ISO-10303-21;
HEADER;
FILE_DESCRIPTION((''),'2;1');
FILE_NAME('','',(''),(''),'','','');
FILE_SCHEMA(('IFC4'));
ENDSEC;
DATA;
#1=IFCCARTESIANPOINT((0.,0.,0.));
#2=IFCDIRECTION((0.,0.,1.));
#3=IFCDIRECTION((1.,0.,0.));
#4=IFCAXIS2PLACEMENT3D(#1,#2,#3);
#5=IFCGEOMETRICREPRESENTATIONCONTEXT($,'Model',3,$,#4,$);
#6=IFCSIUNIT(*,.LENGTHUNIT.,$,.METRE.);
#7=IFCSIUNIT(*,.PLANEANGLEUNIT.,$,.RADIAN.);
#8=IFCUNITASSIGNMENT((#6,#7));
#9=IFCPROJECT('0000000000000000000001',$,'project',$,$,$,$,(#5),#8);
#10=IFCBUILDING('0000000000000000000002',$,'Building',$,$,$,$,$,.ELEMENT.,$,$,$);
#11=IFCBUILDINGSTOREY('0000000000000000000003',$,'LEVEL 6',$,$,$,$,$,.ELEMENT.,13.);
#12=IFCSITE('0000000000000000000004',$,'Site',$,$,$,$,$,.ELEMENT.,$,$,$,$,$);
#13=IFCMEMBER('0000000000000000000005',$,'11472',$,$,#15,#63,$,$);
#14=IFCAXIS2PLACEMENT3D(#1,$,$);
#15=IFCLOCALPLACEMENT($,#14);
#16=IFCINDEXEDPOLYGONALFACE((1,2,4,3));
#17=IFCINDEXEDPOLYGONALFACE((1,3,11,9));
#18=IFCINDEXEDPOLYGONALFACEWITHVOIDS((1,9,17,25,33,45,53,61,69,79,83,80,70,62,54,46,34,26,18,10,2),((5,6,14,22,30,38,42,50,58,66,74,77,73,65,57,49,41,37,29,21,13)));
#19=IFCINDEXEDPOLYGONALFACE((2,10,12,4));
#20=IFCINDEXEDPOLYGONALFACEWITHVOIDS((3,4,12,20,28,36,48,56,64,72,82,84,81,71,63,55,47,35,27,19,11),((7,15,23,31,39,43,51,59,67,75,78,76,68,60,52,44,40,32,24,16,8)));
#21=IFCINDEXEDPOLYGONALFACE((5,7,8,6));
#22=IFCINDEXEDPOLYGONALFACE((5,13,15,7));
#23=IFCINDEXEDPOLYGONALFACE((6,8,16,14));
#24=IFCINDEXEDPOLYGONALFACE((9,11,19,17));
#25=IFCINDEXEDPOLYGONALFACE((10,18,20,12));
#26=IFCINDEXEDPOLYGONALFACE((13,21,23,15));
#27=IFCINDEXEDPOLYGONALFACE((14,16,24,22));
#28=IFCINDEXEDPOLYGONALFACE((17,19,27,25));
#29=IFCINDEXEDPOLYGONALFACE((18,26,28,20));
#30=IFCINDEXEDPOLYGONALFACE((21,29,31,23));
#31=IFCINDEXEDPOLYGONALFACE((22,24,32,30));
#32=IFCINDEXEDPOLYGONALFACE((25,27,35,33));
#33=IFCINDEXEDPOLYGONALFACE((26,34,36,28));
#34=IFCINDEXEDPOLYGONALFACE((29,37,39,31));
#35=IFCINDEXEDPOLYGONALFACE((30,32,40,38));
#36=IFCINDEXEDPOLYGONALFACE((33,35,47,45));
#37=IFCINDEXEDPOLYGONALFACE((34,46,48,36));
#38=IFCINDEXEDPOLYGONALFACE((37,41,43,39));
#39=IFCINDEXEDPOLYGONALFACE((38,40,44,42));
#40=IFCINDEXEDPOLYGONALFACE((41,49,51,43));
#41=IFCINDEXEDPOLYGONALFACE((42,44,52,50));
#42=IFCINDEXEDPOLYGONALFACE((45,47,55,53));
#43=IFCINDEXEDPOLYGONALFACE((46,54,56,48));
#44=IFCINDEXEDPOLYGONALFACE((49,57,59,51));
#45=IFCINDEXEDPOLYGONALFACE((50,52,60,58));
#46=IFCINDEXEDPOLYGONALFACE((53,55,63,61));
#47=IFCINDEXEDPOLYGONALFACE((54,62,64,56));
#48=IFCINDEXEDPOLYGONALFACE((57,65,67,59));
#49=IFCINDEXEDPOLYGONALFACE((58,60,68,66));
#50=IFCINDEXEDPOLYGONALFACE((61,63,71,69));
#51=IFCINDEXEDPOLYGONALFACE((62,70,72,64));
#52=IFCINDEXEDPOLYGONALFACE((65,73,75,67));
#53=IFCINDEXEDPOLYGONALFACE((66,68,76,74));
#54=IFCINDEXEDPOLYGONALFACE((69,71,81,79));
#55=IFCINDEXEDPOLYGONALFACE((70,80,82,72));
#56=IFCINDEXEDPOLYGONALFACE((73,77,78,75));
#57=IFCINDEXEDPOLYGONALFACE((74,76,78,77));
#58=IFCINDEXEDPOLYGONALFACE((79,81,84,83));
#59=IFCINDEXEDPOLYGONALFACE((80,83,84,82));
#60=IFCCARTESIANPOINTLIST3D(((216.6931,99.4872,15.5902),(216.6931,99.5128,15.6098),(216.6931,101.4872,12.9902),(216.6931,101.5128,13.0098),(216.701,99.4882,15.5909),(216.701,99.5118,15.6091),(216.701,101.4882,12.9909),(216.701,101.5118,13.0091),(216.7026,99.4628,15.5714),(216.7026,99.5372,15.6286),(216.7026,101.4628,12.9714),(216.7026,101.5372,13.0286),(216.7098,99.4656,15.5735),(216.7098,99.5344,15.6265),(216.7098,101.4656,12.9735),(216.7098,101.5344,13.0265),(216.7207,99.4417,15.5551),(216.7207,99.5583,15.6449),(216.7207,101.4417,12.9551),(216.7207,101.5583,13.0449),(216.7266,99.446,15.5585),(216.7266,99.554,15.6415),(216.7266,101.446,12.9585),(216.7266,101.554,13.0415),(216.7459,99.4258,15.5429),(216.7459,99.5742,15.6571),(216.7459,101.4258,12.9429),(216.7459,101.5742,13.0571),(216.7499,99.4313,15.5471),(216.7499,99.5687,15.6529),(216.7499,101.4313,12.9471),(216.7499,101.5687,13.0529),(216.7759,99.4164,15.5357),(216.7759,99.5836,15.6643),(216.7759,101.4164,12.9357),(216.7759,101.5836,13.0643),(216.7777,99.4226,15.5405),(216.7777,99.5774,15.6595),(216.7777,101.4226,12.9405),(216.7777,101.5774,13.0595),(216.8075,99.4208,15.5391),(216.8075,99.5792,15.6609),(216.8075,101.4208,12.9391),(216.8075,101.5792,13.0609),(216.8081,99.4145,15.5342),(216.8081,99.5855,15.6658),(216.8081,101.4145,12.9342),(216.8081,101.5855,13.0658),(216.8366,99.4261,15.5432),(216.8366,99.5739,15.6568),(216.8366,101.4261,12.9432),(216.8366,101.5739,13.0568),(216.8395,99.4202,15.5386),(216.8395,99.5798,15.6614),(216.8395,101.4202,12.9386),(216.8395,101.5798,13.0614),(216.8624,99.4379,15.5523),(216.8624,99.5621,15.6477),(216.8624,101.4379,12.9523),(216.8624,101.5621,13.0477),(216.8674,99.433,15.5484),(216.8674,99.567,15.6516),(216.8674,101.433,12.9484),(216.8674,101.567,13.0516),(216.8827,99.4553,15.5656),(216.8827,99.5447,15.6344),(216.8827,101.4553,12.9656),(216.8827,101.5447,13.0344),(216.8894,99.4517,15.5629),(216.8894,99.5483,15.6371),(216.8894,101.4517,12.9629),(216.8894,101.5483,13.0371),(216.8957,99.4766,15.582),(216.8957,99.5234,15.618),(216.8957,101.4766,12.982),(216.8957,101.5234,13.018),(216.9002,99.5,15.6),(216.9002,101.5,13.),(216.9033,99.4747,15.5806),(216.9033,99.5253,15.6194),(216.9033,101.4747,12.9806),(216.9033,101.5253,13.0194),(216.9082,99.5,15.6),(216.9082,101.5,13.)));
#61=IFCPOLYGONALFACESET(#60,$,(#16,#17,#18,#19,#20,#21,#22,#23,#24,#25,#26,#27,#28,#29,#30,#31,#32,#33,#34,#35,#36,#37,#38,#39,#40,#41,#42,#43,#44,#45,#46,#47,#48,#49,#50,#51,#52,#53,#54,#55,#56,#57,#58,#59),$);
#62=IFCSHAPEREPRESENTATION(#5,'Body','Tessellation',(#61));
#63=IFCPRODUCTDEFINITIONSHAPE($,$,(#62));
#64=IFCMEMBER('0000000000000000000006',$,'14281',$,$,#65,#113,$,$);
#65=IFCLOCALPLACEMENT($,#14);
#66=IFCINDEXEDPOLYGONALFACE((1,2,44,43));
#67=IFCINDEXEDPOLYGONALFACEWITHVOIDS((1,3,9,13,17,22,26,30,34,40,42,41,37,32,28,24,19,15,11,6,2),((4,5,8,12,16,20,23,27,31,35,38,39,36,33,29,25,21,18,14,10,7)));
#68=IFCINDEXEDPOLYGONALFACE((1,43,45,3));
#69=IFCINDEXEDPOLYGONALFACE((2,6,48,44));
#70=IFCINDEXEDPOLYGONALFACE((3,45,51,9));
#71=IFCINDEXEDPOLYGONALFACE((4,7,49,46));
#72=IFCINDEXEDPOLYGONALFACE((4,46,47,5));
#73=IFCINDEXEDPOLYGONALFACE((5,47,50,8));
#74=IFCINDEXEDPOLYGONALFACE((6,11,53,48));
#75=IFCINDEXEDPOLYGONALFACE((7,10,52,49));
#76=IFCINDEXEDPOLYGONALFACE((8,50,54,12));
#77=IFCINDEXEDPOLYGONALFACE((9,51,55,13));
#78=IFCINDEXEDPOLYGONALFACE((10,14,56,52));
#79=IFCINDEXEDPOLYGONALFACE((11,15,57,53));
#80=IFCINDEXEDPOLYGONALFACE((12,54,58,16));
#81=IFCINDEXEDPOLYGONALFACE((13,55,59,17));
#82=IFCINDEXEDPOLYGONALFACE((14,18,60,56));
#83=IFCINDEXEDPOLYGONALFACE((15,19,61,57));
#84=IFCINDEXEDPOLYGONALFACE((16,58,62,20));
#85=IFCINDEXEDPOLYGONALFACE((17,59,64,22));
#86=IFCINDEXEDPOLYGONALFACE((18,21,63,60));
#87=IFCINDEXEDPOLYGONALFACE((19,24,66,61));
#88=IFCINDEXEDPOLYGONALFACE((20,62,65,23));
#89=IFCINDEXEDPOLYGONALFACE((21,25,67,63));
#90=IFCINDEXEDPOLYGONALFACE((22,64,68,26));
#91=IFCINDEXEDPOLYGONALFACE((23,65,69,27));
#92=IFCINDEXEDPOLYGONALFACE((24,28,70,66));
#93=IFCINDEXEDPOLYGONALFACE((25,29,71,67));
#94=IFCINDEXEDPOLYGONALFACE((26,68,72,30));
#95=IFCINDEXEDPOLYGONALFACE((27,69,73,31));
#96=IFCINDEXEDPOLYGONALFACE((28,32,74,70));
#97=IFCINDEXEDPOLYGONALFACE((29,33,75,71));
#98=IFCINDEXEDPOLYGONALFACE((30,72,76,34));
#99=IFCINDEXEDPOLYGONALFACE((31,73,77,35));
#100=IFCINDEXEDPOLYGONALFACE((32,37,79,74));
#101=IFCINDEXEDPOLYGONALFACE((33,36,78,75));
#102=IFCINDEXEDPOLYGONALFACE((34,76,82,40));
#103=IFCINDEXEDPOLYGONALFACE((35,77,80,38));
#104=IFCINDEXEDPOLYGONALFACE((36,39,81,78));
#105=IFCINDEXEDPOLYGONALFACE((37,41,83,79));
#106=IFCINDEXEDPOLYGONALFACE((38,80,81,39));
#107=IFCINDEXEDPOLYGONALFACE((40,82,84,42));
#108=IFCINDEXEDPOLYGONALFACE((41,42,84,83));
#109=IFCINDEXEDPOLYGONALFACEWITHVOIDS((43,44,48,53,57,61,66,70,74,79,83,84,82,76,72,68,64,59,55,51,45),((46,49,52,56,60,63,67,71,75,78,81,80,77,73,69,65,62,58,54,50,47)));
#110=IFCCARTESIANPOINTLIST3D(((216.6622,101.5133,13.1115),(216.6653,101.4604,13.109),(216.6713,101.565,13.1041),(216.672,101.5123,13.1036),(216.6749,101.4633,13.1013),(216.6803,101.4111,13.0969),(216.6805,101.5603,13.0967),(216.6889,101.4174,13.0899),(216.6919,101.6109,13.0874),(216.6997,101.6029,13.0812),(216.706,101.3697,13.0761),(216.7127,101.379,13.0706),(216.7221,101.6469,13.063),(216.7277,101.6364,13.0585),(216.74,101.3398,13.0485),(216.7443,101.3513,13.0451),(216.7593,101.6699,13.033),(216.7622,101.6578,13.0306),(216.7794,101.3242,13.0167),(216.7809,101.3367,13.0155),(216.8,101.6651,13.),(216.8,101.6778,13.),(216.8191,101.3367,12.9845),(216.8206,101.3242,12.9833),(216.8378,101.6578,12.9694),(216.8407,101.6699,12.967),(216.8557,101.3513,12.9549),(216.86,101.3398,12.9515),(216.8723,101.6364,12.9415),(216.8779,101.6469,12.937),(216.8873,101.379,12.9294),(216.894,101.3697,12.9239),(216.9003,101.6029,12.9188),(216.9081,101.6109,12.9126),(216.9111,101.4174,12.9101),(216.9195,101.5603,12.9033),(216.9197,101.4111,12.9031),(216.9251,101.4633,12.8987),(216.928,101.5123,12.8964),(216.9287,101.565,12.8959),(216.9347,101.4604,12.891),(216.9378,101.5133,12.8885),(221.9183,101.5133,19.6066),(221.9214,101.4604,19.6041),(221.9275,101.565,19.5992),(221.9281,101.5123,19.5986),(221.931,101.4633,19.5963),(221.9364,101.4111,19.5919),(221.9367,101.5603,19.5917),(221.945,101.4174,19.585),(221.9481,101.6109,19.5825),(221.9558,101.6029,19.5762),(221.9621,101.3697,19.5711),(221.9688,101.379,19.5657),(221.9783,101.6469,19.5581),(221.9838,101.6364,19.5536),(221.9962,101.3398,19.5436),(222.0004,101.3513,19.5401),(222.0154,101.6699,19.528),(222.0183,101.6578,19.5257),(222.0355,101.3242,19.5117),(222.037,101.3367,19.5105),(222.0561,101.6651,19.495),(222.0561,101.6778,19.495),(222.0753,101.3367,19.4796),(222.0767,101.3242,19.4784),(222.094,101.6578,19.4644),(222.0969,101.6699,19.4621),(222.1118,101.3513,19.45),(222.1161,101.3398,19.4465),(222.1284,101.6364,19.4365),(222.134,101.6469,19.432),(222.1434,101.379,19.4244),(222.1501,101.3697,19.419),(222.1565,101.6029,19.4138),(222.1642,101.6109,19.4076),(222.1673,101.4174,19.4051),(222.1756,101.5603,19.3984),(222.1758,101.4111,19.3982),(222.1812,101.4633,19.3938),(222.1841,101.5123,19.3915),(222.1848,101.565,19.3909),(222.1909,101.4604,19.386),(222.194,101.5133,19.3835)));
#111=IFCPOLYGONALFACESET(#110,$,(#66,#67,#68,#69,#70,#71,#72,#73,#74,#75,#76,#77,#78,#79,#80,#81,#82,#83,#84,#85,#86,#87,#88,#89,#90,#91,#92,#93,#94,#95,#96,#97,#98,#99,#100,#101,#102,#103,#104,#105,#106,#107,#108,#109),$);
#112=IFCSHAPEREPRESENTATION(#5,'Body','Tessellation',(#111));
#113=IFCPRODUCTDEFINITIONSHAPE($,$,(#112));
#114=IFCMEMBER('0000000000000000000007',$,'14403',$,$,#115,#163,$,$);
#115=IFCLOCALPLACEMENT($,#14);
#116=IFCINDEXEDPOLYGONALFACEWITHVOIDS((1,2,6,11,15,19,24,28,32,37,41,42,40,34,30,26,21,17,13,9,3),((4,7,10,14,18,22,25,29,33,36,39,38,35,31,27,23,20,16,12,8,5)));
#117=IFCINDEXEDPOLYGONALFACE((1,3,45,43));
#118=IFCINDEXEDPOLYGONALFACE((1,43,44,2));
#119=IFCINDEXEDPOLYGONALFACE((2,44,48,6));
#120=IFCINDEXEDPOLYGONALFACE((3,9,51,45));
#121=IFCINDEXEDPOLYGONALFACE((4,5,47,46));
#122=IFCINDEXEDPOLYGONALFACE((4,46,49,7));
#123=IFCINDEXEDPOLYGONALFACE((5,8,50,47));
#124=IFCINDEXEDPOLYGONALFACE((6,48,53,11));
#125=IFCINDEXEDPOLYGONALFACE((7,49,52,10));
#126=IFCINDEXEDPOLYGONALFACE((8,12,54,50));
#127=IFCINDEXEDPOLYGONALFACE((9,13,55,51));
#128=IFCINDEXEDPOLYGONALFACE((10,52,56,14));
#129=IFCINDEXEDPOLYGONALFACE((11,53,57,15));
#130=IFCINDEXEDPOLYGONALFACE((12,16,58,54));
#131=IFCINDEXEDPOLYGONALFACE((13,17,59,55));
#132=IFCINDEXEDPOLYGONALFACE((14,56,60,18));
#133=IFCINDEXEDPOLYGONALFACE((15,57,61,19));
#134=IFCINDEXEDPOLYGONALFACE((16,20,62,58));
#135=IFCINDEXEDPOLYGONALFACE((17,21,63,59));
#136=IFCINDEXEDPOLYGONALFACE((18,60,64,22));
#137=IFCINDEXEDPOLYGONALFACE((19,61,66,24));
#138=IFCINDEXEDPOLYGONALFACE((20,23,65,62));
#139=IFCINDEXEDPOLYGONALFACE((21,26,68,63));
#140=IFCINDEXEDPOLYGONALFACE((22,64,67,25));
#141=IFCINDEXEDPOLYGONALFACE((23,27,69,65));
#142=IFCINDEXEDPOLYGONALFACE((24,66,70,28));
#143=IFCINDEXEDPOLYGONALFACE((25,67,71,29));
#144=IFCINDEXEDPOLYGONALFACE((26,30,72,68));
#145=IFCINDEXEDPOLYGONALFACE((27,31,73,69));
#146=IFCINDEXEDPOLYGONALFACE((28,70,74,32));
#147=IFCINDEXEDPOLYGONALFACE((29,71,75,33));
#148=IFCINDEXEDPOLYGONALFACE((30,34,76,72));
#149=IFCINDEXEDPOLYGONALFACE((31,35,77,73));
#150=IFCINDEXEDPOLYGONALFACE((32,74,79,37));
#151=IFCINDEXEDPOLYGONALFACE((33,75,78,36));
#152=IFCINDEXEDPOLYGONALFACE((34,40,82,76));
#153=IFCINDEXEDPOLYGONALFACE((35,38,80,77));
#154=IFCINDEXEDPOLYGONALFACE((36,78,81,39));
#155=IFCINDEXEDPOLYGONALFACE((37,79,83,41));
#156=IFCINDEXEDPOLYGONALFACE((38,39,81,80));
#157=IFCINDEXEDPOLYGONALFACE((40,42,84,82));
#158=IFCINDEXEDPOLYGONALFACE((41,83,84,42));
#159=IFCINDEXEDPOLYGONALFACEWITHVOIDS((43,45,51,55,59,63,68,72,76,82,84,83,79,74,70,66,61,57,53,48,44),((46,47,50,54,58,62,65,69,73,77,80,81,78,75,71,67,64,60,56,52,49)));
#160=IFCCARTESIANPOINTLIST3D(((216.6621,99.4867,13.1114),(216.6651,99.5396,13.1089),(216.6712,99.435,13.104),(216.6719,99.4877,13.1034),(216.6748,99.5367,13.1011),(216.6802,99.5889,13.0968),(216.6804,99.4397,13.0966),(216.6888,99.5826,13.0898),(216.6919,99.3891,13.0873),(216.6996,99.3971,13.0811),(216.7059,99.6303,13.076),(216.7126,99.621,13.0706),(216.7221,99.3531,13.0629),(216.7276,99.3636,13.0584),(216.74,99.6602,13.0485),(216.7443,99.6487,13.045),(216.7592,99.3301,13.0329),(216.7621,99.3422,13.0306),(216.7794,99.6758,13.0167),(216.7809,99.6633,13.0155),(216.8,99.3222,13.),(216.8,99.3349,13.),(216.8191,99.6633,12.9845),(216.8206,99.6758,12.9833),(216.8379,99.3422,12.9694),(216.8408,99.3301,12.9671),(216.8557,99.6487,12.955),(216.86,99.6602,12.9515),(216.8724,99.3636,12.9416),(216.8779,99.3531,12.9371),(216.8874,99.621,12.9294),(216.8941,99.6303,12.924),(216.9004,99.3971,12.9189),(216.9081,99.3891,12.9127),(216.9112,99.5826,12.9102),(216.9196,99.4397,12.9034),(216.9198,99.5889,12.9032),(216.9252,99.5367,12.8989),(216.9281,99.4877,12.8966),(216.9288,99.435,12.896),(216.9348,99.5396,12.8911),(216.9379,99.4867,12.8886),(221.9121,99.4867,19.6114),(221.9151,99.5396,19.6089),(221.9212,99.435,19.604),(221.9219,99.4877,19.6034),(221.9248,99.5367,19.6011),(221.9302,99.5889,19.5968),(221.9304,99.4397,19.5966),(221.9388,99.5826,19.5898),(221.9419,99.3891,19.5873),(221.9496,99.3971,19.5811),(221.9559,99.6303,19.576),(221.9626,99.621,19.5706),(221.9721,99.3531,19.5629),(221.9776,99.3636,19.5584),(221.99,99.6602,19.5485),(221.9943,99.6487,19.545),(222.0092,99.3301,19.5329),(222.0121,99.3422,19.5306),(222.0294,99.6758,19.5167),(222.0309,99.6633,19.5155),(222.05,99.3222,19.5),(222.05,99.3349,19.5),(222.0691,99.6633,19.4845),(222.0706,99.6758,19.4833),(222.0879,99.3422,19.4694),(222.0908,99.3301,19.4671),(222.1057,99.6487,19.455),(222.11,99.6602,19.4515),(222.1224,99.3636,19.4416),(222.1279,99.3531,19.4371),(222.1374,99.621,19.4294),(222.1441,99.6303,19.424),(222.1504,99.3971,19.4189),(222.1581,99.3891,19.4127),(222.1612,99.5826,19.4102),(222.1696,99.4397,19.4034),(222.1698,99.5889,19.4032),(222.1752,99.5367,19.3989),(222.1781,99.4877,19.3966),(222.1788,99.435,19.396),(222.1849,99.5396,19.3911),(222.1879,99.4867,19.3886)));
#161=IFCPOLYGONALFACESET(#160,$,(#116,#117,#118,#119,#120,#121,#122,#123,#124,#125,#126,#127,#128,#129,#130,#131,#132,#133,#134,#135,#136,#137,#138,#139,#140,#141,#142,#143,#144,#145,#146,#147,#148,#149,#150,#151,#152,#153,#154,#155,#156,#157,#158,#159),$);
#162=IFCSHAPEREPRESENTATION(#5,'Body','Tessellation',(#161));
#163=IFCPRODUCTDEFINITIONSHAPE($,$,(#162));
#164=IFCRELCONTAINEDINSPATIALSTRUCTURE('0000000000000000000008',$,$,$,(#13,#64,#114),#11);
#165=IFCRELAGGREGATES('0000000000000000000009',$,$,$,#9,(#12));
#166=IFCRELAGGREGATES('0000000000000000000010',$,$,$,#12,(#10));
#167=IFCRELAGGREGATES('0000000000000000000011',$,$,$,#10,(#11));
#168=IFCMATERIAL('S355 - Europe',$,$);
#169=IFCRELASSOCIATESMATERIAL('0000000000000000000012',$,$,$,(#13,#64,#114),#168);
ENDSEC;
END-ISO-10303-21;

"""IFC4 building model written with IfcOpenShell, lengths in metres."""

from ifc_helpers import new_model, si_unit, frame, origin_with_axes, origin_2d_with_axis, place, context, project, spatial, hollow_circle, extrude, material, material_profile, profile_set, profile_usage, element, save


model = new_model("IFC4")

# Units and contexts
model_context = context("Model", 3, world=origin_with_axes())
ifc_project = project(units=[si_unit("LENGTHUNIT", "METRE"), si_unit("PLANEANGLEUNIT", "RADIAN")], contexts=[model_context])

# Site, building, storey
site = spatial("IfcSite", under=ifc_project, Name="Site", CompositionType="ELEMENT")
building = spatial("IfcBuilding", under=site, Name="Building", CompositionType="ELEMENT")
storey = spatial("IfcBuildingStorey", under=building, Name="LEVEL 6", CompositionType="ELEMENT", Elevation=13.0)

# Shared definitions
ifc_material = material(Name="S355 - Europe")

# Members
ifc_material_profile_1 = material_profile(ifc_material, hollow_circle(Radius=0.1081, WallThickness=0.008, at=origin_2d_with_axis()))
ifc_profile_set_1 = profile_set([ifc_material_profile_1])
ifc_profile_usage_1 = profile_usage(ifc_profile_set_1, cardinal=10)
member_1_placement = place(None, frame((216.8, 101.5, 13.0), z_axis=(0.0, -0.609711, 0.792624), x_axis=(1.0, 0.0, 0.0)))
element("IfcMember", 1, at=member_1_placement, inside=storey, material=ifc_profile_usage_1, Name="11472", context=model_context, shape_type="SweptSolid", body=[
    extrude(hollow_circle(Radius=0.1081, WallThickness=0.008, at=origin_2d_with_axis()), origin_with_axes(), (0.0, 0.0, 1.0), 3.2802),
])
ifc_material_profile_2 = material_profile(ifc_material, hollow_circle(Radius=0.1778, WallThickness=0.0127, at=origin_2d_with_axis()))
ifc_profile_set_2 = profile_set([ifc_material_profile_2])
ifc_profile_usage_2 = profile_usage(ifc_profile_set_2, cardinal=10)
member_2_placement = place(None, frame((216.8, 101.5, 13.0), z_axis=(0.62907, 0.0, 0.777349), x_axis=(0.0, 1.0, 0.0)))
element("IfcMember", 2, at=member_2_placement, inside=storey, material=ifc_profile_usage_2, Name="14281", context=model_context, shape_type="SweptSolid", body=[
    extrude(hollow_circle(Radius=0.1778, WallThickness=0.0127, at=origin_2d_with_axis()), origin_with_axes(), (0.0, 0.0, 1.0), 8.3554),
])
ifc_material_profile_3 = material_profile(ifc_material, hollow_circle(Radius=0.1778, WallThickness=0.0127, at=origin_2d_with_axis()))
ifc_profile_set_3 = profile_set([ifc_material_profile_3])
ifc_profile_usage_3 = profile_usage(ifc_profile_set_3, cardinal=10)
member_3_placement = place(None, frame((222.05, 99.5, 19.5), z_axis=(-0.628337, 0.0, -0.777941), x_axis=(0.0, -1.0, 0.0)))
element("IfcMember", 3, at=member_3_placement, inside=storey, material=ifc_profile_usage_3, Name="14403", context=model_context, shape_type="SweptSolid", body=[
    extrude(hollow_circle(Radius=0.1778, WallThickness=0.0127, at=origin_2d_with_axis()), origin_with_axes(), (0.0, 0.0, 1.0), 8.3554),
])

save(model, "model.ifc")
